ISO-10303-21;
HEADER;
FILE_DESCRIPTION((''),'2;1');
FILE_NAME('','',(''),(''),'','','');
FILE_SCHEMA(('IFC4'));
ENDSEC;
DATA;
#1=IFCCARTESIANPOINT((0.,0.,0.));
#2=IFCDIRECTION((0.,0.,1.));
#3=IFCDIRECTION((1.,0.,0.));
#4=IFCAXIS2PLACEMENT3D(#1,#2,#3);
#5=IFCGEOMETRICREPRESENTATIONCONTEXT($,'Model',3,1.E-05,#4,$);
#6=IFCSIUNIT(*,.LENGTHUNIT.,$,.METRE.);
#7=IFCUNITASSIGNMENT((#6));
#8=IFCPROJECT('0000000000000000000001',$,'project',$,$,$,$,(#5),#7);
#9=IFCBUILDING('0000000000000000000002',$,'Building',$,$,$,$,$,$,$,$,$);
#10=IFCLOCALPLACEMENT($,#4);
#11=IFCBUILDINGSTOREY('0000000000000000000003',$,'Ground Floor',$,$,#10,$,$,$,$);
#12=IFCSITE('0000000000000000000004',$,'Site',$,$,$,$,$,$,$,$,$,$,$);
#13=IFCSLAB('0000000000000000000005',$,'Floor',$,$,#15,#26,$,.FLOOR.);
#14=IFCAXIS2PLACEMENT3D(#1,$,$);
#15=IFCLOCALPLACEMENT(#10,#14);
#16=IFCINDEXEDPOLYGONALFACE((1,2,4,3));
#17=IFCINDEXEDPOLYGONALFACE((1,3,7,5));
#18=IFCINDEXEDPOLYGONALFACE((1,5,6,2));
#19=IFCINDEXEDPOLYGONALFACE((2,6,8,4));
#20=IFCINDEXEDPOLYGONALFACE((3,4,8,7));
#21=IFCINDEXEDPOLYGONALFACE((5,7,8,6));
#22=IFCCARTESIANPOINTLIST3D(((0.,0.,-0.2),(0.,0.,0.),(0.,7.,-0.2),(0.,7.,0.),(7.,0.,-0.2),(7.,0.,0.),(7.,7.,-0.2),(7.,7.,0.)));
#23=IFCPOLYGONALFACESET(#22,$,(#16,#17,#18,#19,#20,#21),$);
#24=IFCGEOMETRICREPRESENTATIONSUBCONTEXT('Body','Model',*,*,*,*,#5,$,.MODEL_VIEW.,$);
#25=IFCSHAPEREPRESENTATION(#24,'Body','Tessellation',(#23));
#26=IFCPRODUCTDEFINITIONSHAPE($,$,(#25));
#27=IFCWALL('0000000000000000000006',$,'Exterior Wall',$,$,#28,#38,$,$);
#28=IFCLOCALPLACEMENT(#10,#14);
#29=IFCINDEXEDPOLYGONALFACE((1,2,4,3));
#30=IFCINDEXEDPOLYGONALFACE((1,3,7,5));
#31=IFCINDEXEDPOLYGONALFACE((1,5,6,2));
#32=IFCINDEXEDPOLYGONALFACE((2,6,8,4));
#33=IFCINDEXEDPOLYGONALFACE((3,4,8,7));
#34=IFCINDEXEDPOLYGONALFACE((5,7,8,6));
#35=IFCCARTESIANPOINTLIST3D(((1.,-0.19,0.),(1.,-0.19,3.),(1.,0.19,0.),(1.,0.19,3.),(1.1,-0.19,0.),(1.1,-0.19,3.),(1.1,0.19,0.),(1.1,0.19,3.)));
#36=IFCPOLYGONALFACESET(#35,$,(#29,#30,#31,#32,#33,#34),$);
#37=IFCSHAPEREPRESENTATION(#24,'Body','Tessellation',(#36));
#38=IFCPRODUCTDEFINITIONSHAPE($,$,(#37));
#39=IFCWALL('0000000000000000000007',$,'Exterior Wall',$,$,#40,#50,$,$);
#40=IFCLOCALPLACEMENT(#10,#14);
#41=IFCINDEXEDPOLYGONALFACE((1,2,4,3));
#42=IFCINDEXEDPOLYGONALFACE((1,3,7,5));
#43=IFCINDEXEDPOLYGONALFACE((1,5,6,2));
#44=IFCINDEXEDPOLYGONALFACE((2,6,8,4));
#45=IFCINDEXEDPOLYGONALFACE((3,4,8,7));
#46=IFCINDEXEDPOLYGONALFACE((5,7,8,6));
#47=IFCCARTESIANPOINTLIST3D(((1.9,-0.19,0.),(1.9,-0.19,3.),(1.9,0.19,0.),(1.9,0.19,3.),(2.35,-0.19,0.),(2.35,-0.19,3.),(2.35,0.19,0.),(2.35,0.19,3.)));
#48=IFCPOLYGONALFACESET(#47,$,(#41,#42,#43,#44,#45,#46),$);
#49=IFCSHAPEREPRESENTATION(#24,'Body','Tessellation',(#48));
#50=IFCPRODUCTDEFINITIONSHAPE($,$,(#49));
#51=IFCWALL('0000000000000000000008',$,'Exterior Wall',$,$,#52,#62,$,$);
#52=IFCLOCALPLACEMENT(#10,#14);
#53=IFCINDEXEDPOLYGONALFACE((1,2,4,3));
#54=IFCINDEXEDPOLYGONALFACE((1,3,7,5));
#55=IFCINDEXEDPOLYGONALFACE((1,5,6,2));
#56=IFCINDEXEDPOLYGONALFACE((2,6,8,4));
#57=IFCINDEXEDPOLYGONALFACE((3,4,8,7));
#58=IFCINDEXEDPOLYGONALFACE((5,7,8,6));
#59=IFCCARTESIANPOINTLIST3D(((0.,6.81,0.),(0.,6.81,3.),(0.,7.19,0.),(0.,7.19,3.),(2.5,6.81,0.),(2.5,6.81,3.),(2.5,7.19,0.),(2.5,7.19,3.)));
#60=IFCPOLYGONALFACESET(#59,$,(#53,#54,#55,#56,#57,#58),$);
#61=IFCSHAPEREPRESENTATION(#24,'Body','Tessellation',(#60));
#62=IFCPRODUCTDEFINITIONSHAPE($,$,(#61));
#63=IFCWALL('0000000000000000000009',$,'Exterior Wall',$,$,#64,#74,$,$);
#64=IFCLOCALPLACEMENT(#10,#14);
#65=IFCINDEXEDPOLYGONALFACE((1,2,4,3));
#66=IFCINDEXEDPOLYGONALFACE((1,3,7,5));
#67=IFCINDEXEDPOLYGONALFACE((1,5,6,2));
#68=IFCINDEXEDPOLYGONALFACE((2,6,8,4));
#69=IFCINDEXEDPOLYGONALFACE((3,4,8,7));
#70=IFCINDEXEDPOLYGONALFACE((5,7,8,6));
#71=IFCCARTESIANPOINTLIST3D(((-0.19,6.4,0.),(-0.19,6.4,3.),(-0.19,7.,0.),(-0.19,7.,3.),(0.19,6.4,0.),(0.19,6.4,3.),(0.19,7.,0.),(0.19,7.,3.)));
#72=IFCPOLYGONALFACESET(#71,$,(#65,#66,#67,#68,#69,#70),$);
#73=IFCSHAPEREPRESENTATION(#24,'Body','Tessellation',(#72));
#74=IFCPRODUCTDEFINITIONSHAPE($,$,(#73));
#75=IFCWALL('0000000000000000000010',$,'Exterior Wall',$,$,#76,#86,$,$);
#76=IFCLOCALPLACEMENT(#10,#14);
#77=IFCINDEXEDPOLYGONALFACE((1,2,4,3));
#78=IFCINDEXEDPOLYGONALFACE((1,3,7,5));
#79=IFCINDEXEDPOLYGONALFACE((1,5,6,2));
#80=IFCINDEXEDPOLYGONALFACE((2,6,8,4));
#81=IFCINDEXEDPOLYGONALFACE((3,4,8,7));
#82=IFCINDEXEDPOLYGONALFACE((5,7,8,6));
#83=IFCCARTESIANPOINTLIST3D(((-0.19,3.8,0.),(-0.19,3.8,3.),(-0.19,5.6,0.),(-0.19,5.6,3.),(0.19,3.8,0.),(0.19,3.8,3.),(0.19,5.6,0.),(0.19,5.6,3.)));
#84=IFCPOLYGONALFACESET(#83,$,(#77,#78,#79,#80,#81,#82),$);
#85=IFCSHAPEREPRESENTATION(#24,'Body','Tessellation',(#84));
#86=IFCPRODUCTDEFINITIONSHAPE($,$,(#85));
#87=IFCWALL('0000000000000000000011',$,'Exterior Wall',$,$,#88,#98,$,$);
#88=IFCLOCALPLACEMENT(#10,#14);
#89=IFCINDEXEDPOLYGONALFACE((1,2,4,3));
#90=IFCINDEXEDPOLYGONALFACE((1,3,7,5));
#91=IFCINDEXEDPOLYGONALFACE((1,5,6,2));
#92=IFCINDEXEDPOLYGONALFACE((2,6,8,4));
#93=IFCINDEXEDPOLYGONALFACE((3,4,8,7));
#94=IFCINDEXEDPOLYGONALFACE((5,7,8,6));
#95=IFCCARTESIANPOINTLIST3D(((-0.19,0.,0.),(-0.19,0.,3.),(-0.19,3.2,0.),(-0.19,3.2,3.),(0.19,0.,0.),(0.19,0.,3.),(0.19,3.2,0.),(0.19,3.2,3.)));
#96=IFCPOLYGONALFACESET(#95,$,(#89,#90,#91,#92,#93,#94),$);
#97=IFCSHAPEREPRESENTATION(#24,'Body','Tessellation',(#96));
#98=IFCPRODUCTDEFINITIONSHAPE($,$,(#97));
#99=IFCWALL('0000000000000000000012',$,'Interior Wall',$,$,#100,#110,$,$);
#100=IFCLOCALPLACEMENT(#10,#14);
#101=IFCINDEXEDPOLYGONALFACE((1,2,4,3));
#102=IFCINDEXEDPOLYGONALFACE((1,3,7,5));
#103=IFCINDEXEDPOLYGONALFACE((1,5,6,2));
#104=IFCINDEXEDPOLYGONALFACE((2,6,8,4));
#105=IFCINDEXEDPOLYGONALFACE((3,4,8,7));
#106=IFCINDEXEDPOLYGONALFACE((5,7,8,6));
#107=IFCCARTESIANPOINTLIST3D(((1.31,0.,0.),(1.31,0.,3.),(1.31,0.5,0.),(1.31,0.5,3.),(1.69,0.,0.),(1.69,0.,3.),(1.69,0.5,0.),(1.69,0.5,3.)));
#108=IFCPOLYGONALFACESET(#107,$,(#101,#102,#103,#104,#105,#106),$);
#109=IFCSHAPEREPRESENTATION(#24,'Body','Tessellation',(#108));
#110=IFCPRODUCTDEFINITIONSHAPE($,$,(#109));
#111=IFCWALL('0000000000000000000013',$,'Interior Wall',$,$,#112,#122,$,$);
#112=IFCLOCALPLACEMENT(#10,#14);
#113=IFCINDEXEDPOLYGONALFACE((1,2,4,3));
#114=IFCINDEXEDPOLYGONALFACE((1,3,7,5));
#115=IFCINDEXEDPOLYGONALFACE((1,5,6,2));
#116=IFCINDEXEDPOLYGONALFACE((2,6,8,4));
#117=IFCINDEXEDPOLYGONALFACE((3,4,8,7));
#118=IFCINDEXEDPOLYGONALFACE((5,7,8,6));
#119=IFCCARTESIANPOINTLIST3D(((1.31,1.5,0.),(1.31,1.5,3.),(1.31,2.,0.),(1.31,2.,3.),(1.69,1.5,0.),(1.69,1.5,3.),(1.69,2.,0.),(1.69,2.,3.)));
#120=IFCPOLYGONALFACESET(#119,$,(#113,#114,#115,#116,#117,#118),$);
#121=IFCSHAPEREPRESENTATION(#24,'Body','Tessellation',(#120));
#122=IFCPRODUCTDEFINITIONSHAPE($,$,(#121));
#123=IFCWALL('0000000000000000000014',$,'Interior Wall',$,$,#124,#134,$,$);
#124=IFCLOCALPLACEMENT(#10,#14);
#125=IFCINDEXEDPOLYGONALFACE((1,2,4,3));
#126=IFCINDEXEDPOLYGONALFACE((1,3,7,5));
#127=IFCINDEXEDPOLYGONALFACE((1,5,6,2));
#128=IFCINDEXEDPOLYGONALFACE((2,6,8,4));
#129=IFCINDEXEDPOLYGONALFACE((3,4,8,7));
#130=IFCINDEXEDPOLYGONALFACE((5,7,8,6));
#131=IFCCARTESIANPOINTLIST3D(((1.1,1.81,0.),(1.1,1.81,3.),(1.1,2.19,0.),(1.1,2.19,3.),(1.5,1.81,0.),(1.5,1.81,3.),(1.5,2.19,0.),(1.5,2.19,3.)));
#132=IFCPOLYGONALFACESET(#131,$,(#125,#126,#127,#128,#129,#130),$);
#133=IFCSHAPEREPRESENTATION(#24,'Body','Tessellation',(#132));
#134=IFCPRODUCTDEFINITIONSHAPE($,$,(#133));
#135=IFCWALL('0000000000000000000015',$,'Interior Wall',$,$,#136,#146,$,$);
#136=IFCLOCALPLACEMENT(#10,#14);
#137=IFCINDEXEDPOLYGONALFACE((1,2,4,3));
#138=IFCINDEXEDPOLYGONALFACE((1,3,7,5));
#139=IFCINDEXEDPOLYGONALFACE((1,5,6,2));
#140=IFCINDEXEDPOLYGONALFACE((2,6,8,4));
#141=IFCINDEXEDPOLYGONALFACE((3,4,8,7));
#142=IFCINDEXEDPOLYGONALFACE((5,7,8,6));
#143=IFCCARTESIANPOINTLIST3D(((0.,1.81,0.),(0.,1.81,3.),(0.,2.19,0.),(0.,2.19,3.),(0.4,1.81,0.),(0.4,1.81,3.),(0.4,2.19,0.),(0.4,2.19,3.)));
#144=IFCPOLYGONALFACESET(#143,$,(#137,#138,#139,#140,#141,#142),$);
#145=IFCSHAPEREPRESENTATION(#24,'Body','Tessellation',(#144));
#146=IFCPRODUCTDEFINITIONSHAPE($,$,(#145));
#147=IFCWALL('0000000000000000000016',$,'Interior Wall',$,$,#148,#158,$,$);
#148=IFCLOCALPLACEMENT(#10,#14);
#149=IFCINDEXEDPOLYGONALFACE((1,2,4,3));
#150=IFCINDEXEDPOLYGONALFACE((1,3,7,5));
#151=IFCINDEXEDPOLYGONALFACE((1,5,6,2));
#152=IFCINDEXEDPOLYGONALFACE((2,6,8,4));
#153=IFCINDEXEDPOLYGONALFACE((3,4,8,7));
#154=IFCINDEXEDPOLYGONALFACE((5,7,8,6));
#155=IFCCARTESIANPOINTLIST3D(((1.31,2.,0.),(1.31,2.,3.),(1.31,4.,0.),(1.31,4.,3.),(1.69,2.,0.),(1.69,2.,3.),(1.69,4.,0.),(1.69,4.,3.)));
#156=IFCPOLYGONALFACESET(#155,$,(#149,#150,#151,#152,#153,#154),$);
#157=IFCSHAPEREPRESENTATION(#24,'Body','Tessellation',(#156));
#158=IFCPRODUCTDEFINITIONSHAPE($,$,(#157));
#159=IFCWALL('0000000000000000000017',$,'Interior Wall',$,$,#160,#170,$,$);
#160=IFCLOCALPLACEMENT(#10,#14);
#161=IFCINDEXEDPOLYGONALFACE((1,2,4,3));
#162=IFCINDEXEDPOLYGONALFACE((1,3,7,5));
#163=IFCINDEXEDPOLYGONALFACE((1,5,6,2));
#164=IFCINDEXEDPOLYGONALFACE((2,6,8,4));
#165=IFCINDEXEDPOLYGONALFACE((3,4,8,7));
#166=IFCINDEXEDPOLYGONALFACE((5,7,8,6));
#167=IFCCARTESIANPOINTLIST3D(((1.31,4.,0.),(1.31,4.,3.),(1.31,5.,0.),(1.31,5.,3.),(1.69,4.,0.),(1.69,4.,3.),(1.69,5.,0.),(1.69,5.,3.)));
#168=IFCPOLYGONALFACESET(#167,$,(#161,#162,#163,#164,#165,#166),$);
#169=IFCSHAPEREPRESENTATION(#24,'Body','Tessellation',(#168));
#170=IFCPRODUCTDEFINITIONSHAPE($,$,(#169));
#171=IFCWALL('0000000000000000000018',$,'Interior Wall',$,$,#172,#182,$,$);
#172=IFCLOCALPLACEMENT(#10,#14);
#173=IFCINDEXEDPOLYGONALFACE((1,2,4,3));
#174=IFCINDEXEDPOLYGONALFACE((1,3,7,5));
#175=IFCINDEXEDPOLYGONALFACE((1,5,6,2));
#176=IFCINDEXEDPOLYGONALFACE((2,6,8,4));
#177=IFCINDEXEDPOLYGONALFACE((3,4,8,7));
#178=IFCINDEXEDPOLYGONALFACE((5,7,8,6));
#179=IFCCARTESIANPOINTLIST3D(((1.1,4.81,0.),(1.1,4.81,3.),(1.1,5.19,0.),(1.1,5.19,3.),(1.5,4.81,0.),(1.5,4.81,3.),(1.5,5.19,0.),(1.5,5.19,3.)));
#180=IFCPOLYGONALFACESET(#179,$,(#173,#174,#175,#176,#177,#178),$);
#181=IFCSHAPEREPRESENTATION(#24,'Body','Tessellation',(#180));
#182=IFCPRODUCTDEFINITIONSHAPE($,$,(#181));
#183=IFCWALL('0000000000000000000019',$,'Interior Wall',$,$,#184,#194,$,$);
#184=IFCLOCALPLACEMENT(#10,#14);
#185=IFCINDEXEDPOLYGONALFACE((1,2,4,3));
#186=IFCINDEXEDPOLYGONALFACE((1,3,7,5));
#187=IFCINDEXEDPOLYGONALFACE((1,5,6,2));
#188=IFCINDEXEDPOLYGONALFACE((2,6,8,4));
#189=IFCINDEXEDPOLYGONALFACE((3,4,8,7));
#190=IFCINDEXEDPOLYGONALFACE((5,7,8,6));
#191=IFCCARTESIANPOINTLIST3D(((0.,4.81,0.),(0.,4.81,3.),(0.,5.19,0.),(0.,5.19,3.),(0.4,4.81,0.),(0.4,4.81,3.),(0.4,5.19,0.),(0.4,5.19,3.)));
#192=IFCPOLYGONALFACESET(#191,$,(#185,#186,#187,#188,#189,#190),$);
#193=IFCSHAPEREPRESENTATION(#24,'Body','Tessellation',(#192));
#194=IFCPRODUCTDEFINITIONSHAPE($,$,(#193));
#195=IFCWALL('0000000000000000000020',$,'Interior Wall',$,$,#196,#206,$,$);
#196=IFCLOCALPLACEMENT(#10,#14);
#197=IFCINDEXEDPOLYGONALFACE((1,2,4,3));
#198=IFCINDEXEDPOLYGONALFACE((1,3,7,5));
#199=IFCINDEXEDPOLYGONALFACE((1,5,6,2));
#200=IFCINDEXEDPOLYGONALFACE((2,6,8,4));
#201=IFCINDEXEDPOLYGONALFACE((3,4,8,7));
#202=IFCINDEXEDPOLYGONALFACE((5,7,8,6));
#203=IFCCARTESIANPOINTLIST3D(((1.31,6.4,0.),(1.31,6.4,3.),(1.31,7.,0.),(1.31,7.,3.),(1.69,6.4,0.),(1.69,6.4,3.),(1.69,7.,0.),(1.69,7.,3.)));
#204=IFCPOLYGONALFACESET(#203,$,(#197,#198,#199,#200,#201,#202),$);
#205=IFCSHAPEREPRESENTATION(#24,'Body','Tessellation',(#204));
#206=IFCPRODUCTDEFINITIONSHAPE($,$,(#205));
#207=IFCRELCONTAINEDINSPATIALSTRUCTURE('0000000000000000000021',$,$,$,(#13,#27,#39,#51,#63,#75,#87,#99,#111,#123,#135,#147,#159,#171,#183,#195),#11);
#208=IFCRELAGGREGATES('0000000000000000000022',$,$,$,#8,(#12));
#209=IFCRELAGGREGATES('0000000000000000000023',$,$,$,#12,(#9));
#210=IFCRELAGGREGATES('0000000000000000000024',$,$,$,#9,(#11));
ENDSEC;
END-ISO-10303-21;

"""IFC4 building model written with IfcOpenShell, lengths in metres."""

from ifc_helpers import new_model, si_unit, frame, origin_with_axes, place, context, subcontext, project, spatial, indexed_curve, outline, extrude, element, save


model = new_model("IFC4")

# Units and contexts
model_context = context("Model", 3, precision=1e-05, world=origin_with_axes())
body_context = subcontext(model_context, "Body", "Model", "MODEL_VIEW")
ifc_project = project(units=[si_unit("LENGTHUNIT", "METRE")], contexts=[model_context])

# Site, building, storey
site = spatial("IfcSite", under=ifc_project, Name="Site")
building = spatial("IfcBuilding", under=site, Name="Building")
storey_placement = place(None, origin_with_axes())
storey = spatial("IfcBuildingStorey", under=building, at=storey_placement, Name="Ground Floor")

# Slab
slab_placement = place(storey_placement, frame((0.0, 0.0, -0.2), z_axis=(0.0, 0.0, 1.0), x_axis=(1.0, 0.0, 0.0)))
element("IfcSlab", 1, at=slab_placement, inside=storey, Name="Floor", PredefinedType="FLOOR", context=body_context, shape_type="SweptSolid", body=[
    extrude(outline(indexed_curve([(0.0, 0.0), (7.0, 0.0), (7.0, 7.0), (0.0, 7.0)])), None, (0.0, 0.0, 1.0), 0.2),
])

# Walls
wall_1_placement = place(storey_placement, frame((1.0, 0.0, 0.0), z_axis=(0.0, 0.0, 1.0), x_axis=(1.0, 0.0, 0.0)))
element("IfcWall", 2, at=wall_1_placement, inside=storey, Name="Exterior Wall", context=body_context, shape_type="SweptSolid", body=[
    extrude(outline(indexed_curve([(0.0, 0.0), (0.0, 0.38), (0.1, 0.38), (0.1, 0.0), (0.0, 0.0)], self_intersect=False)), frame((0.0, -0.19, 0.0), z_axis=(0.0, 0.0, 1.0), x_axis=(1.0, 0.0, 0.0)), (0.0, 0.0, 1.0), 3.0),
])
wall_2_placement = place(storey_placement, frame((1.9, 0.0, 0.0), z_axis=(0.0, 0.0, 1.0), x_axis=(1.0, 0.0, 0.0)))
element("IfcWall", 3, at=wall_2_placement, inside=storey, Name="Exterior Wall", context=body_context, shape_type="SweptSolid", body=[
    extrude(outline(indexed_curve([(0.0, 0.0), (0.0, 0.38), (0.45, 0.38), (0.45, 0.0), (0.0, 0.0)], self_intersect=False)), frame((0.0, -0.19, 0.0), z_axis=(0.0, 0.0, 1.0), x_axis=(1.0, 0.0, 0.0)), (0.0, 0.0, 1.0), 3.0),
])
wall_3_placement = place(storey_placement, frame((2.5, 7.0, 0.0), z_axis=(0.0, 0.0, 1.0), x_axis=(-1.0, 0.0, 0.0)))
element("IfcWall", 4, at=wall_3_placement, inside=storey, Name="Exterior Wall", context=body_context, shape_type="SweptSolid", body=[
    extrude(outline(indexed_curve([(0.0, 0.0), (0.0, 0.38), (2.5, 0.38), (2.5, 0.0), (0.0, 0.0)], self_intersect=False)), frame((0.0, -0.19, 0.0), z_axis=(0.0, 0.0, 1.0), x_axis=(1.0, 0.0, 0.0)), (0.0, 0.0, 1.0), 3.0),
])
wall_4_placement = place(storey_placement, frame((0.0, 7.0, 0.0), z_axis=(0.0, 0.0, 1.0), x_axis=(0.0, -1.0, 0.0)))
element("IfcWall", 5, at=wall_4_placement, inside=storey, Name="Exterior Wall", context=body_context, shape_type="SweptSolid", body=[
    extrude(outline(indexed_curve([(0.0, 0.0), (0.0, 0.38), (0.6, 0.38), (0.6, 0.0), (0.0, 0.0)], self_intersect=False)), frame((0.0, -0.19, 0.0), z_axis=(0.0, 0.0, 1.0), x_axis=(1.0, 0.0, 0.0)), (0.0, 0.0, 1.0), 3.0),
])
wall_5_placement = place(storey_placement, frame((0.0, 5.6, 0.0), z_axis=(0.0, 0.0, 1.0), x_axis=(0.0, -1.0, 0.0)))
element("IfcWall", 6, at=wall_5_placement, inside=storey, Name="Exterior Wall", context=body_context, shape_type="SweptSolid", body=[
    extrude(outline(indexed_curve([(0.0, 0.0), (0.0, 0.38), (1.8, 0.38), (1.8, 0.0), (0.0, 0.0)], self_intersect=False)), frame((0.0, -0.19, 0.0), z_axis=(0.0, 0.0, 1.0), x_axis=(1.0, 0.0, 0.0)), (0.0, 0.0, 1.0), 3.0),
])
wall_6_placement = place(storey_placement, frame((0.0, 3.2, 0.0), z_axis=(0.0, 0.0, 1.0), x_axis=(0.0, -1.0, 0.0)))
element("IfcWall", 7, at=wall_6_placement, inside=storey, Name="Exterior Wall", context=body_context, shape_type="SweptSolid", body=[
    extrude(outline(indexed_curve([(0.0, 0.0), (0.0, 0.38), (3.2, 0.38), (3.2, 0.0), (0.0, 0.0)], self_intersect=False)), frame((0.0, -0.19, 0.0), z_axis=(0.0, 0.0, 1.0), x_axis=(1.0, 0.0, 0.0)), (0.0, 0.0, 1.0), 3.0),
])
for number, where, z_axis, x_axis, name in (
    (8, (1.5, 0.0, 0.0), (0.0, 0.0, 1.0), (0.0, 1.0, 0.0), "Interior Wall"),
    (9, (1.5, 1.5, 0.0), (0.0, 0.0, 1.0), (0.0, 1.0, 0.0), "Interior Wall"),
):
    element("IfcWall", number, at=place(storey_placement, frame(where, z_axis=z_axis, x_axis=x_axis)), inside=storey, Name=name, context=body_context, shape_type="SweptSolid", body=[
        extrude(outline(indexed_curve([(0.0, 0.0), (0.0, 0.38), (0.5, 0.38), (0.5, 0.0), (0.0, 0.0)], self_intersect=False)), frame((0.0, -0.19, 0.0), z_axis=(0.0, 0.0, 1.0), x_axis=(1.0, 0.0, 0.0)), (0.0, 0.0, 1.0), 3.0),
    ])
for number, where, z_axis, x_axis, name in (
    (10, (1.5, 2.0, 0.0), (0.0, 0.0, 1.0), (-1.0, 0.0, 0.0), "Interior Wall"),
    (11, (0.4, 2.0, 0.0), (0.0, 0.0, 1.0), (-1.0, 0.0, 0.0), "Interior Wall"),
):
    element("IfcWall", number, at=place(storey_placement, frame(where, z_axis=z_axis, x_axis=x_axis)), inside=storey, Name=name, context=body_context, shape_type="SweptSolid", body=[
        extrude(outline(indexed_curve([(0.0, 0.0), (0.0, 0.38), (0.4, 0.38), (0.4, 0.0), (0.0, 0.0)], self_intersect=False)), frame((0.0, -0.19, 0.0), z_axis=(0.0, 0.0, 1.0), x_axis=(1.0, 0.0, 0.0)), (0.0, 0.0, 1.0), 3.0),
    ])
wall_7_placement = place(storey_placement, frame((1.5, 4.0, 0.0), z_axis=(0.0, 0.0, 1.0), x_axis=(0.0, -1.0, 0.0)))
element("IfcWall", 12, at=wall_7_placement, inside=storey, Name="Interior Wall", context=body_context, shape_type="SweptSolid", body=[
    extrude(outline(indexed_curve([(0.0, 0.0), (0.0, 0.38), (2.0, 0.38), (2.0, 0.0), (0.0, 0.0)], self_intersect=False)), frame((0.0, -0.19, 0.0), z_axis=(0.0, 0.0, 1.0), x_axis=(1.0, 0.0, 0.0)), (0.0, 0.0, 1.0), 3.0),
])
wall_8_placement = place(storey_placement, frame((1.5, 4.0, 0.0), z_axis=(0.0, 0.0, 1.0), x_axis=(0.0, 1.0, 0.0)))
element("IfcWall", 13, at=wall_8_placement, inside=storey, Name="Interior Wall", context=body_context, shape_type="SweptSolid", body=[
    extrude(outline(indexed_curve([(0.0, 0.0), (0.0, 0.38), (1.0, 0.38), (1.0, 0.0), (0.0, 0.0)], self_intersect=False)), frame((0.0, -0.19, 0.0), z_axis=(0.0, 0.0, 1.0), x_axis=(1.0, 0.0, 0.0)), (0.0, 0.0, 1.0), 3.0),
])
for number, where, z_axis, x_axis, name in (
    (14, (1.5, 5.0, 0.0), (0.0, 0.0, 1.0), (-1.0, 0.0, 0.0), "Interior Wall"),
    (15, (0.4, 5.0, 0.0), (0.0, 0.0, 1.0), (-1.0, 0.0, 0.0), "Interior Wall"),
):
    element("IfcWall", number, at=place(storey_placement, frame(where, z_axis=z_axis, x_axis=x_axis)), inside=storey, Name=name, context=body_context, shape_type="SweptSolid", body=[
        extrude(outline(indexed_curve([(0.0, 0.0), (0.0, 0.38), (0.4, 0.38), (0.4, 0.0), (0.0, 0.0)], self_intersect=False)), frame((0.0, -0.19, 0.0), z_axis=(0.0, 0.0, 1.0), x_axis=(1.0, 0.0, 0.0)), (0.0, 0.0, 1.0), 3.0),
    ])
for number, where, z_axis, x_axis, name in (
    (16, (1.5, 7.0, 0.0), (0.0, 0.0, 1.0), (0.0, -1.0, 0.0), "Interior Wall"),
):
    element("IfcWall", number, at=place(storey_placement, frame(where, z_axis=z_axis, x_axis=x_axis)), inside=storey, Name=name, context=body_context, shape_type="SweptSolid", body=[
        extrude(outline(indexed_curve([(0.0, 0.0), (0.0, 0.38), (0.6, 0.38), (0.6, 0.0), (0.0, 0.0)], self_intersect=False)), frame((0.0, -0.19, 0.0), z_axis=(0.0, 0.0, 1.0), x_axis=(1.0, 0.0, 0.0)), (0.0, 0.0, 1.0), 3.0),
    ])

save(model, "model.ifc")
